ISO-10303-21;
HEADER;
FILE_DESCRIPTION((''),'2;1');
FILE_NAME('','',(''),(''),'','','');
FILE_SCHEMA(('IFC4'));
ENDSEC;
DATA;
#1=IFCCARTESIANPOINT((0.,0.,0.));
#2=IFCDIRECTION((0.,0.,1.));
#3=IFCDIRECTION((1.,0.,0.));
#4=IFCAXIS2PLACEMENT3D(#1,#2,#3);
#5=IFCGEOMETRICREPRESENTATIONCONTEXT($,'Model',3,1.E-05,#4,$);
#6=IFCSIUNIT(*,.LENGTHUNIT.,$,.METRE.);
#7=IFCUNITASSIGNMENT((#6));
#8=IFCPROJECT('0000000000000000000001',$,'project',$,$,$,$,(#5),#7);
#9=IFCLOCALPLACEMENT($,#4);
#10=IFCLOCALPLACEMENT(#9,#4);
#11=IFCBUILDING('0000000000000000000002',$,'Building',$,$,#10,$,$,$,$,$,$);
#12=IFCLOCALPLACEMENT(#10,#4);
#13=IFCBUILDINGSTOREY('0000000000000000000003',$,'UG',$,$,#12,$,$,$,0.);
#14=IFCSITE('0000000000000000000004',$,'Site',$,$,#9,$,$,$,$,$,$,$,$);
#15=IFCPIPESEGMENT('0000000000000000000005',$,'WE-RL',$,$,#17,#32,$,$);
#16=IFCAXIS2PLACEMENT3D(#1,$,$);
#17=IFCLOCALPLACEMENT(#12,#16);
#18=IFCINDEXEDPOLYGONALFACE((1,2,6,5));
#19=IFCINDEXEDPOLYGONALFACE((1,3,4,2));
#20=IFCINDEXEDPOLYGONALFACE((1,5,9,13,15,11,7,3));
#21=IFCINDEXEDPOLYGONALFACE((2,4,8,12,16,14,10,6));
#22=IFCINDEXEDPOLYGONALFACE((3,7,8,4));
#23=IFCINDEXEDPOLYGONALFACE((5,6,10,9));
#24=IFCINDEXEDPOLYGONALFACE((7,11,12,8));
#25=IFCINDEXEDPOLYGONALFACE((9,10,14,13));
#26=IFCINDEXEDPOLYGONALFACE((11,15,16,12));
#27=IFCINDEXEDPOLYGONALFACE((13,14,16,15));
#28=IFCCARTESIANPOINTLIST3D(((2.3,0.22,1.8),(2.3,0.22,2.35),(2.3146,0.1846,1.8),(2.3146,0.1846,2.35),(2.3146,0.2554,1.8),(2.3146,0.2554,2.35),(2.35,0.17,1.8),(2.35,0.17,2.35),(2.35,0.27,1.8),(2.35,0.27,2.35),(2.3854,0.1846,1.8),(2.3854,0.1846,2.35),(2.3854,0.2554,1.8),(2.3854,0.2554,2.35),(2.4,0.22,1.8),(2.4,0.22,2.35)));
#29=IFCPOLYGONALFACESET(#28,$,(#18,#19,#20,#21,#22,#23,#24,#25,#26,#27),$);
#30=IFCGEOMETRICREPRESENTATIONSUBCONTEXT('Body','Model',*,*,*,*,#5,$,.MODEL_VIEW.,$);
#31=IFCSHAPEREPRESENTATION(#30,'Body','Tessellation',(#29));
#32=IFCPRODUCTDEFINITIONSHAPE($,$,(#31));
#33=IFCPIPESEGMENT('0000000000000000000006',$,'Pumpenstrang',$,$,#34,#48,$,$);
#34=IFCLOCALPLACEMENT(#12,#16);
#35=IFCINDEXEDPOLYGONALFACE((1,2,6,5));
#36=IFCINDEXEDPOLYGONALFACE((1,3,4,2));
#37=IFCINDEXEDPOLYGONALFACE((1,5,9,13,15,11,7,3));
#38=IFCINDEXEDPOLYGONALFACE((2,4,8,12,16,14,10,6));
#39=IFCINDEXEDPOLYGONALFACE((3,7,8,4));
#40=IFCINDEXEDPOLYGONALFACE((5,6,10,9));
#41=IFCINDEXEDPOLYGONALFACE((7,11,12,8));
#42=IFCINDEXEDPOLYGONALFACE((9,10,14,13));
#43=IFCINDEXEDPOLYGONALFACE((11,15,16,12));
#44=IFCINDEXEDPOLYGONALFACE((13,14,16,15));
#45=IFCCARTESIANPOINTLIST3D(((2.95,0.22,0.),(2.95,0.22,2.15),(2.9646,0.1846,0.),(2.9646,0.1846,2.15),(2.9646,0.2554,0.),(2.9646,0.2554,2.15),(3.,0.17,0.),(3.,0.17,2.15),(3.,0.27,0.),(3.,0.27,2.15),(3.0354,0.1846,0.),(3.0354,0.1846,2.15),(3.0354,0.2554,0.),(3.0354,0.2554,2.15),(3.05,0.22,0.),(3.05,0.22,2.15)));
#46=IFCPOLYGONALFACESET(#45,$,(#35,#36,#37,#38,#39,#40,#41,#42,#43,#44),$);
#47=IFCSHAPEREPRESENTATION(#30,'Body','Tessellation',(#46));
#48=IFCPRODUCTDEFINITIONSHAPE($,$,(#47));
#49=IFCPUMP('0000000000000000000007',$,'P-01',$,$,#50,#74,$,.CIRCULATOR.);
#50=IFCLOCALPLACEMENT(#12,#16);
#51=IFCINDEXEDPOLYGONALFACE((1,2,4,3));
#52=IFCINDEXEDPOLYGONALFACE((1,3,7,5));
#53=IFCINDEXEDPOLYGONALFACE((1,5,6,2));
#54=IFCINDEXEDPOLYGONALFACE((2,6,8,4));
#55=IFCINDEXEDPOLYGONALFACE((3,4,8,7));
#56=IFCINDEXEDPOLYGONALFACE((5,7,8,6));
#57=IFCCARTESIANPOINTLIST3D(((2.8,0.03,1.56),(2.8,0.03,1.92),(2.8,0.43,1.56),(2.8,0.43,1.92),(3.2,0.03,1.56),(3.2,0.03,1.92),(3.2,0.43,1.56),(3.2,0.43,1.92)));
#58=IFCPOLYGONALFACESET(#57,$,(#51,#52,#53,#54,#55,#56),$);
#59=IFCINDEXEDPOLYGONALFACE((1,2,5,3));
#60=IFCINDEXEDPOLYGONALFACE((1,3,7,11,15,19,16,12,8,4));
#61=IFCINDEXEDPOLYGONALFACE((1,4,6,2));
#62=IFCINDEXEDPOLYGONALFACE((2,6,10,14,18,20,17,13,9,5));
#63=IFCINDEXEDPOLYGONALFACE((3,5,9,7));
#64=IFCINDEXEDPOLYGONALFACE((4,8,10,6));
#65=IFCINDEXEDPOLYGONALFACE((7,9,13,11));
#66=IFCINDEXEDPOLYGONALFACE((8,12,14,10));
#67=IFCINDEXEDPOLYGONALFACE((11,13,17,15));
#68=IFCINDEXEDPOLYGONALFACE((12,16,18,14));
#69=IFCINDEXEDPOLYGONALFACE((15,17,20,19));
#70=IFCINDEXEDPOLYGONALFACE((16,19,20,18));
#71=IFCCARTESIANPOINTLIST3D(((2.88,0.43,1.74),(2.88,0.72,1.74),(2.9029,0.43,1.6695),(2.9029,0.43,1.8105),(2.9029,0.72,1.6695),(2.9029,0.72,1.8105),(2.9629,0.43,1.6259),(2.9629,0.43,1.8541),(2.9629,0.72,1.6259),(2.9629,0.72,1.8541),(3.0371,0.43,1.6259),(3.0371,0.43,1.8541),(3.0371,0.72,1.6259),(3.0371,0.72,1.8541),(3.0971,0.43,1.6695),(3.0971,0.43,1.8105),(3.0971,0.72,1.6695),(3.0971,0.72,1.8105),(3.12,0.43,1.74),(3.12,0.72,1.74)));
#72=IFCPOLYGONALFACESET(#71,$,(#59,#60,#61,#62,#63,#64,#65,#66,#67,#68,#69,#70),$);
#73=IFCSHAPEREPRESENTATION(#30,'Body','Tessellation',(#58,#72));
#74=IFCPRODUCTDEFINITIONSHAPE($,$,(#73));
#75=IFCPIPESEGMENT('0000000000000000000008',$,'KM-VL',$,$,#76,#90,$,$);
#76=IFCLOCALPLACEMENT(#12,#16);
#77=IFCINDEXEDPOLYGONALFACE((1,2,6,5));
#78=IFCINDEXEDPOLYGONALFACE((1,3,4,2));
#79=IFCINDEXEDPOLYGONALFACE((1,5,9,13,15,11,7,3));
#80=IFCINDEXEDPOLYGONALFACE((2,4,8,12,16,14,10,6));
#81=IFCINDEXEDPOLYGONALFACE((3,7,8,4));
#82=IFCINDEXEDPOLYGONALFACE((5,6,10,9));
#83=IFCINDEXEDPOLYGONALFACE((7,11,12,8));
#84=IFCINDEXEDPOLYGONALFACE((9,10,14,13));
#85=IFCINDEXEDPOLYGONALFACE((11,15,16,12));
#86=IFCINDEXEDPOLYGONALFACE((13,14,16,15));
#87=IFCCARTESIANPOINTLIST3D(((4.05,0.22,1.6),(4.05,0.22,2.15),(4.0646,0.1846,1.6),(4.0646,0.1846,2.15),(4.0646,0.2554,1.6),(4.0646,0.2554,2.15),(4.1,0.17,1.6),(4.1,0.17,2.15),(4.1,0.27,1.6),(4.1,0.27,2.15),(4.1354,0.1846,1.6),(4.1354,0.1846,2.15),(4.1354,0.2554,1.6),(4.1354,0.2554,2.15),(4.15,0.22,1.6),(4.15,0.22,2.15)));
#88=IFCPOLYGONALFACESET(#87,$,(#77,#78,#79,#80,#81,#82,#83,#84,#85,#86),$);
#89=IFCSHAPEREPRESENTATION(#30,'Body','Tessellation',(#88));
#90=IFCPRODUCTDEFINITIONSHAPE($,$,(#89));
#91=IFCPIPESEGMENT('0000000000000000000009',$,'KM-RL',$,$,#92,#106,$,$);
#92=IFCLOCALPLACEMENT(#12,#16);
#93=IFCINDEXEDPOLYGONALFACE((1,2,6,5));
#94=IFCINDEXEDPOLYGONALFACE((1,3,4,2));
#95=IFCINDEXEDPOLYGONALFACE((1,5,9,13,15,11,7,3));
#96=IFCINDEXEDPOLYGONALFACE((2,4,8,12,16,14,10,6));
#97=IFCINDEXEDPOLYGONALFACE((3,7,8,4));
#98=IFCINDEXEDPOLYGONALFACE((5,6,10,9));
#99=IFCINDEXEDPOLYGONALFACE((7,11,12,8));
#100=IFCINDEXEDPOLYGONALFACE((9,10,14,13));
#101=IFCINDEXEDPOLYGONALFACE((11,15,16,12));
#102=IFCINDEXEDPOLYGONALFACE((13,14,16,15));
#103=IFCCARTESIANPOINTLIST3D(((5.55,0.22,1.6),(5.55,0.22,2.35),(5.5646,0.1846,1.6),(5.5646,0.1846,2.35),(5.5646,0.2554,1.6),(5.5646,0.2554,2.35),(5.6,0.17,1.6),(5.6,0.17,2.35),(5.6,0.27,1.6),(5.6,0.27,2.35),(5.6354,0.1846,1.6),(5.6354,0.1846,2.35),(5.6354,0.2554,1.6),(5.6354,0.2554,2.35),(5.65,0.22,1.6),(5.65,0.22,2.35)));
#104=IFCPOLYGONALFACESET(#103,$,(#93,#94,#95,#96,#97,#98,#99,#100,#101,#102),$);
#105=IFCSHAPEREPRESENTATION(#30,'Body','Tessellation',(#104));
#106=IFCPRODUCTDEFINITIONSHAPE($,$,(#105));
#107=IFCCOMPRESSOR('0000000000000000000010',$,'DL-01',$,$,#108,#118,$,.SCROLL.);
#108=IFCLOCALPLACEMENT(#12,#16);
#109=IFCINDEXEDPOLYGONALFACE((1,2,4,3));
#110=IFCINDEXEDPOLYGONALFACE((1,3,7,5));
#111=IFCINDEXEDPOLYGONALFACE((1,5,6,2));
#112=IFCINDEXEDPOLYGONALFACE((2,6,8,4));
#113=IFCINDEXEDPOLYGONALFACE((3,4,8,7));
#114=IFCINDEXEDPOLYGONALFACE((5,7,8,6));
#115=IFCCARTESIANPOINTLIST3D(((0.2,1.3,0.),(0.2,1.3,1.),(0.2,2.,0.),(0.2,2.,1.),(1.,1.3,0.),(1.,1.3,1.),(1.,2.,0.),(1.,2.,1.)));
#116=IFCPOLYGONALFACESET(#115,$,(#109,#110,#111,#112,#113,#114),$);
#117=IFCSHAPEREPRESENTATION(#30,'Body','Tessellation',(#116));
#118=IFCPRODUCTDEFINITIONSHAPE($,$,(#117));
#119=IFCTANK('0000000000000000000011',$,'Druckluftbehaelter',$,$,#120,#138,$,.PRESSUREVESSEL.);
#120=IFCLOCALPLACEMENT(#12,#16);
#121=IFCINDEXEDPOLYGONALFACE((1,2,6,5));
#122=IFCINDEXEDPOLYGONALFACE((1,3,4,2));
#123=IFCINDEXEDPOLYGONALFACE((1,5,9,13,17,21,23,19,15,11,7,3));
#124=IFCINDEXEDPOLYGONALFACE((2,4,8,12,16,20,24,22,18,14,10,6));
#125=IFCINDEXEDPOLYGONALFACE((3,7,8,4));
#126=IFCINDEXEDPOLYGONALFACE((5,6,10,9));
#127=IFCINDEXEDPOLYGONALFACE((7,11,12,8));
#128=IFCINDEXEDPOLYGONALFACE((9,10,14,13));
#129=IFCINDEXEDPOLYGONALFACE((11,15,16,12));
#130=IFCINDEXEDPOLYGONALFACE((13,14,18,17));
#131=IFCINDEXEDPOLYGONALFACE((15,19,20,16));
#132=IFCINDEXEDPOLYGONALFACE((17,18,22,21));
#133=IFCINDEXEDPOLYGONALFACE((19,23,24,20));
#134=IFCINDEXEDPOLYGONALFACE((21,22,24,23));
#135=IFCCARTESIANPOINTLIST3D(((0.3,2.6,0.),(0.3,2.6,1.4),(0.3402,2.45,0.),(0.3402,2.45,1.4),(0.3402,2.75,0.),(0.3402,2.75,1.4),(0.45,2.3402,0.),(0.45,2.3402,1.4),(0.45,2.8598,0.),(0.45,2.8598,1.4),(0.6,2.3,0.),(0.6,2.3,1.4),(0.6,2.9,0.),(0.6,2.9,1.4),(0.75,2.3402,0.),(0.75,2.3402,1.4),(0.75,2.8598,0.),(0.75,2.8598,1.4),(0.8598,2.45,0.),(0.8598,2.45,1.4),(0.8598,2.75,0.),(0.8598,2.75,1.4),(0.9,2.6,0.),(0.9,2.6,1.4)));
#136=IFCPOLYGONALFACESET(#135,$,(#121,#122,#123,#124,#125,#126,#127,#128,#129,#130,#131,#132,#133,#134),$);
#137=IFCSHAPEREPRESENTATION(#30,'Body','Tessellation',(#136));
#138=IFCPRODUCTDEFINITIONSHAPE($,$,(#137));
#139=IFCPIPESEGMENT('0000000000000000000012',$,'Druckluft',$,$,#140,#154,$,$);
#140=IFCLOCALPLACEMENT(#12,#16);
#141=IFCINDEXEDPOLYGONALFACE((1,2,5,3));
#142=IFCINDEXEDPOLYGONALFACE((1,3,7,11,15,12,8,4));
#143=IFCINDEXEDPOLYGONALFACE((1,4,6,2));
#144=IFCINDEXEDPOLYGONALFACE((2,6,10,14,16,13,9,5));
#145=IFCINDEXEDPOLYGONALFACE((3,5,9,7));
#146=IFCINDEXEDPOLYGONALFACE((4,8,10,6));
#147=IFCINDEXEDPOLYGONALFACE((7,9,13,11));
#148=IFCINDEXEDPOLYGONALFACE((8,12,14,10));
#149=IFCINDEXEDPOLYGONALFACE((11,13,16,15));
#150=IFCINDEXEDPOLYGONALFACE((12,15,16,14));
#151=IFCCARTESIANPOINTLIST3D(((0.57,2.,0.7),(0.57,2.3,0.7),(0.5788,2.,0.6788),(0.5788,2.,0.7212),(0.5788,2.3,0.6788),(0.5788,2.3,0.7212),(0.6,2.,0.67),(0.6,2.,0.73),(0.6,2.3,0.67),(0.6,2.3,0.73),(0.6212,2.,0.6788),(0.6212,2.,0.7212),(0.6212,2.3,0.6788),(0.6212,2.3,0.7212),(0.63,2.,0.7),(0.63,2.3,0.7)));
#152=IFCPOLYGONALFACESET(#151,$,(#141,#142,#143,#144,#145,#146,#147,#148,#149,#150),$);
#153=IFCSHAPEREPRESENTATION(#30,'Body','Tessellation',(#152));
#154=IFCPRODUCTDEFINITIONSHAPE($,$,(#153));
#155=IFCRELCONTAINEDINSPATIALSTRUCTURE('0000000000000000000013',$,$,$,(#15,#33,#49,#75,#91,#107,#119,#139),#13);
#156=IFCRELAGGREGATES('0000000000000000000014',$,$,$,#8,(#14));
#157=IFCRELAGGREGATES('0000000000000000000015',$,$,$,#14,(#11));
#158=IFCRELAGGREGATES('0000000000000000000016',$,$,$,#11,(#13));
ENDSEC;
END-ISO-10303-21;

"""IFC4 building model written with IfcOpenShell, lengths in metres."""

from ifc_helpers import new_model, si_unit, frame, origin_with_axes, place, context, subcontext, project, spatial, polyline, outline, extrude, element, save


model = new_model("IFC4")

# Units and contexts
model_context = context("Model", 3, precision=1e-05, world=origin_with_axes())
body_context = subcontext(model_context, "Body", "Model", "MODEL_VIEW")
ifc_project = project(units=[si_unit("LENGTHUNIT", "METRE")], contexts=[model_context])

# Site, building, storey
site_placement = place(None, origin_with_axes())
site = spatial("IfcSite", under=ifc_project, at=site_placement, Name="Site")
building_placement = place(site_placement, origin_with_axes())
building = spatial("IfcBuilding", under=site, at=building_placement, Name="Building")
storey_placement = place(building_placement, origin_with_axes())
storey = spatial("IfcBuildingStorey", under=building, at=storey_placement, Name="UG", Elevation=0.0)

# Pipe segments
pipe_segment_1_placement = place(storey_placement, origin_with_axes())
element("IfcPipeSegment", 1, at=pipe_segment_1_placement, inside=storey, Name="WE-RL", context=body_context, shape_type="SweptSolid", body=[
    extrude(outline(polyline([(0.05, 0.0, 0.0), (0.0354, 0.0354, 0.0), (0.0, 0.05, 0.0), (-0.0354, 0.0354, 0.0), (-0.05, 0.0, 0.0), (-0.0354, -0.0354, 0.0), (0.0, -0.05, 0.0), (0.0354, -0.0354, 0.0), (0.05, 0.0, 0.0)])), frame((2.35, 0.22, 1.8), z_axis=(0.0, 0.0, 1.0), x_axis=(1.0, 0.0, 0.0)), (0.0, 0.0, 1.0), 0.55),
])
pipe_segment_2_placement = place(storey_placement, origin_with_axes())
element("IfcPipeSegment", 2, at=pipe_segment_2_placement, inside=storey, Name="Pumpenstrang", context=body_context, shape_type="SweptSolid", body=[
    extrude(outline(polyline([(0.05, 0.0, 0.0), (0.0354, 0.0354, 0.0), (0.0, 0.05, 0.0), (-0.0354, 0.0354, 0.0), (-0.05, 0.0, 0.0), (-0.0354, -0.0354, 0.0), (0.0, -0.05, 0.0), (0.0354, -0.0354, 0.0), (0.05, 0.0, 0.0)])), frame((3.0, 0.22, 0.0), z_axis=(0.0, 0.0, 1.0), x_axis=(1.0, 0.0, 0.0)), (0.0, 0.0, 1.0), 2.15),
])

# Pump
pump_placement = place(storey_placement, origin_with_axes())
element("IfcPump", 3, at=pump_placement, inside=storey, Name="P-01", PredefinedType="CIRCULATOR", context=body_context, shape_type="SweptSolid", body=[
    extrude(outline(polyline([(2.8, 0.03, 0.0), (3.2, 0.03, 0.0), (3.2, 0.43, 0.0), (2.8, 0.43, 0.0), (2.8, 0.03, 0.0)])), frame((0.0, 0.0, 1.56), z_axis=(0.0, 0.0, 1.0), x_axis=(1.0, 0.0, 0.0)), (0.0, 0.0, 1.0), 0.36),
    extrude(outline(polyline([(0.12, 0.0, 0.0), (0.0971, 0.0705, 0.0), (0.0371, 0.1141, 0.0), (-0.0371, 0.1141, 0.0), (-0.0971, 0.0705, 0.0), (-0.12, 0.0, 0.0), (-0.0971, -0.0705, 0.0), (-0.0371, -0.1141, 0.0), (0.0371, -0.1141, 0.0), (0.0971, -0.0705, 0.0), (0.12, 0.0, 0.0)])), frame((3.0, 0.43, 1.74), z_axis=(0.0, 1.0, 0.0), x_axis=(-1.0, 0.0, 0.0)), (0.0, 0.0, 1.0), 0.29),
])

# Pipe segments
pipe_segment_3_placement = place(storey_placement, origin_with_axes())
element("IfcPipeSegment", 4, at=pipe_segment_3_placement, inside=storey, Name="KM-VL", context=body_context, shape_type="SweptSolid", body=[
    extrude(outline(polyline([(0.05, 0.0, 0.0), (0.0354, 0.0354, 0.0), (0.0, 0.05, 0.0), (-0.0354, 0.0354, 0.0), (-0.05, 0.0, 0.0), (-0.0354, -0.0354, 0.0), (0.0, -0.05, 0.0), (0.0354, -0.0354, 0.0), (0.05, 0.0, 0.0)])), frame((4.1, 0.22, 1.6), z_axis=(0.0, 0.0, 1.0), x_axis=(1.0, 0.0, 0.0)), (0.0, 0.0, 1.0), 0.55),
])
pipe_segment_4_placement = place(storey_placement, origin_with_axes())
element("IfcPipeSegment", 5, at=pipe_segment_4_placement, inside=storey, Name="KM-RL", context=body_context, shape_type="SweptSolid", body=[
    extrude(outline(polyline([(0.05, 0.0, 0.0), (0.0354, 0.0354, 0.0), (0.0, 0.05, 0.0), (-0.0354, 0.0354, 0.0), (-0.05, 0.0, 0.0), (-0.0354, -0.0354, 0.0), (0.0, -0.05, 0.0), (0.0354, -0.0354, 0.0), (0.05, 0.0, 0.0)])), frame((5.6, 0.22, 1.6), z_axis=(0.0, 0.0, 1.0), x_axis=(1.0, 0.0, 0.0)), (0.0, 0.0, 1.0), 0.75),
])

# Compressor
compressor_placement = place(storey_placement, origin_with_axes())
element("IfcCompressor", 6, at=compressor_placement, inside=storey, Name="DL-01", PredefinedType="SCROLL", context=body_context, shape_type="SweptSolid", body=[
    extrude(outline(polyline([(0.2, 1.3, 0.0), (1.0, 1.3, 0.0), (1.0, 2.0, 0.0), (0.2, 2.0, 0.0), (0.2, 1.3, 0.0)])), origin_with_axes(), (0.0, 0.0, 1.0), 1.0),
])

# Tank
tank_1_placement = place(storey_placement, origin_with_axes())
element("IfcTank", 7, at=tank_1_placement, inside=storey, Name="Druckluftbehaelter", PredefinedType="PRESSUREVESSEL", context=body_context, shape_type="SweptSolid", body=[
    extrude(outline(polyline([(0.3, 0.0, 0.0), (0.2598, 0.15, 0.0), (0.15, 0.2598, 0.0), (0.0, 0.3, 0.0), (-0.15, 0.2598, 0.0), (-0.2598, 0.15, 0.0), (-0.3, 0.0, 0.0), (-0.2598, -0.15, 0.0), (-0.15, -0.2598, 0.0), (0.0, -0.3, 0.0), (0.15, -0.2598, 0.0), (0.2598, -0.15, 0.0), (0.3, 0.0, 0.0)])), frame((0.6, 2.6, 0.0), z_axis=(0.0, 0.0, 1.0), x_axis=(1.0, 0.0, 0.0)), (0.0, 0.0, 1.0), 1.4),
])

# Pipe segment
pipe_segment_5_placement = place(storey_placement, origin_with_axes())
element("IfcPipeSegment", 8, at=pipe_segment_5_placement, inside=storey, Name="Druckluft", context=body_context, shape_type="SweptSolid", body=[
    extrude(outline(polyline([(0.03, 0.0, 0.0), (0.0212, 0.0212, 0.0), (0.0, 0.03, 0.0), (-0.0212, 0.0212, 0.0), (-0.03, 0.0, 0.0), (-0.0212, -0.0212, 0.0), (0.0, -0.03, 0.0), (0.0212, -0.0212, 0.0), (0.03, 0.0, 0.0)])), frame((0.6, 2.0, 0.7), z_axis=(0.0, 1.0, 0.0), x_axis=(-1.0, 0.0, 0.0)), (0.0, 0.0, 1.0), 0.3),
])

save(model, "model.ifc")
